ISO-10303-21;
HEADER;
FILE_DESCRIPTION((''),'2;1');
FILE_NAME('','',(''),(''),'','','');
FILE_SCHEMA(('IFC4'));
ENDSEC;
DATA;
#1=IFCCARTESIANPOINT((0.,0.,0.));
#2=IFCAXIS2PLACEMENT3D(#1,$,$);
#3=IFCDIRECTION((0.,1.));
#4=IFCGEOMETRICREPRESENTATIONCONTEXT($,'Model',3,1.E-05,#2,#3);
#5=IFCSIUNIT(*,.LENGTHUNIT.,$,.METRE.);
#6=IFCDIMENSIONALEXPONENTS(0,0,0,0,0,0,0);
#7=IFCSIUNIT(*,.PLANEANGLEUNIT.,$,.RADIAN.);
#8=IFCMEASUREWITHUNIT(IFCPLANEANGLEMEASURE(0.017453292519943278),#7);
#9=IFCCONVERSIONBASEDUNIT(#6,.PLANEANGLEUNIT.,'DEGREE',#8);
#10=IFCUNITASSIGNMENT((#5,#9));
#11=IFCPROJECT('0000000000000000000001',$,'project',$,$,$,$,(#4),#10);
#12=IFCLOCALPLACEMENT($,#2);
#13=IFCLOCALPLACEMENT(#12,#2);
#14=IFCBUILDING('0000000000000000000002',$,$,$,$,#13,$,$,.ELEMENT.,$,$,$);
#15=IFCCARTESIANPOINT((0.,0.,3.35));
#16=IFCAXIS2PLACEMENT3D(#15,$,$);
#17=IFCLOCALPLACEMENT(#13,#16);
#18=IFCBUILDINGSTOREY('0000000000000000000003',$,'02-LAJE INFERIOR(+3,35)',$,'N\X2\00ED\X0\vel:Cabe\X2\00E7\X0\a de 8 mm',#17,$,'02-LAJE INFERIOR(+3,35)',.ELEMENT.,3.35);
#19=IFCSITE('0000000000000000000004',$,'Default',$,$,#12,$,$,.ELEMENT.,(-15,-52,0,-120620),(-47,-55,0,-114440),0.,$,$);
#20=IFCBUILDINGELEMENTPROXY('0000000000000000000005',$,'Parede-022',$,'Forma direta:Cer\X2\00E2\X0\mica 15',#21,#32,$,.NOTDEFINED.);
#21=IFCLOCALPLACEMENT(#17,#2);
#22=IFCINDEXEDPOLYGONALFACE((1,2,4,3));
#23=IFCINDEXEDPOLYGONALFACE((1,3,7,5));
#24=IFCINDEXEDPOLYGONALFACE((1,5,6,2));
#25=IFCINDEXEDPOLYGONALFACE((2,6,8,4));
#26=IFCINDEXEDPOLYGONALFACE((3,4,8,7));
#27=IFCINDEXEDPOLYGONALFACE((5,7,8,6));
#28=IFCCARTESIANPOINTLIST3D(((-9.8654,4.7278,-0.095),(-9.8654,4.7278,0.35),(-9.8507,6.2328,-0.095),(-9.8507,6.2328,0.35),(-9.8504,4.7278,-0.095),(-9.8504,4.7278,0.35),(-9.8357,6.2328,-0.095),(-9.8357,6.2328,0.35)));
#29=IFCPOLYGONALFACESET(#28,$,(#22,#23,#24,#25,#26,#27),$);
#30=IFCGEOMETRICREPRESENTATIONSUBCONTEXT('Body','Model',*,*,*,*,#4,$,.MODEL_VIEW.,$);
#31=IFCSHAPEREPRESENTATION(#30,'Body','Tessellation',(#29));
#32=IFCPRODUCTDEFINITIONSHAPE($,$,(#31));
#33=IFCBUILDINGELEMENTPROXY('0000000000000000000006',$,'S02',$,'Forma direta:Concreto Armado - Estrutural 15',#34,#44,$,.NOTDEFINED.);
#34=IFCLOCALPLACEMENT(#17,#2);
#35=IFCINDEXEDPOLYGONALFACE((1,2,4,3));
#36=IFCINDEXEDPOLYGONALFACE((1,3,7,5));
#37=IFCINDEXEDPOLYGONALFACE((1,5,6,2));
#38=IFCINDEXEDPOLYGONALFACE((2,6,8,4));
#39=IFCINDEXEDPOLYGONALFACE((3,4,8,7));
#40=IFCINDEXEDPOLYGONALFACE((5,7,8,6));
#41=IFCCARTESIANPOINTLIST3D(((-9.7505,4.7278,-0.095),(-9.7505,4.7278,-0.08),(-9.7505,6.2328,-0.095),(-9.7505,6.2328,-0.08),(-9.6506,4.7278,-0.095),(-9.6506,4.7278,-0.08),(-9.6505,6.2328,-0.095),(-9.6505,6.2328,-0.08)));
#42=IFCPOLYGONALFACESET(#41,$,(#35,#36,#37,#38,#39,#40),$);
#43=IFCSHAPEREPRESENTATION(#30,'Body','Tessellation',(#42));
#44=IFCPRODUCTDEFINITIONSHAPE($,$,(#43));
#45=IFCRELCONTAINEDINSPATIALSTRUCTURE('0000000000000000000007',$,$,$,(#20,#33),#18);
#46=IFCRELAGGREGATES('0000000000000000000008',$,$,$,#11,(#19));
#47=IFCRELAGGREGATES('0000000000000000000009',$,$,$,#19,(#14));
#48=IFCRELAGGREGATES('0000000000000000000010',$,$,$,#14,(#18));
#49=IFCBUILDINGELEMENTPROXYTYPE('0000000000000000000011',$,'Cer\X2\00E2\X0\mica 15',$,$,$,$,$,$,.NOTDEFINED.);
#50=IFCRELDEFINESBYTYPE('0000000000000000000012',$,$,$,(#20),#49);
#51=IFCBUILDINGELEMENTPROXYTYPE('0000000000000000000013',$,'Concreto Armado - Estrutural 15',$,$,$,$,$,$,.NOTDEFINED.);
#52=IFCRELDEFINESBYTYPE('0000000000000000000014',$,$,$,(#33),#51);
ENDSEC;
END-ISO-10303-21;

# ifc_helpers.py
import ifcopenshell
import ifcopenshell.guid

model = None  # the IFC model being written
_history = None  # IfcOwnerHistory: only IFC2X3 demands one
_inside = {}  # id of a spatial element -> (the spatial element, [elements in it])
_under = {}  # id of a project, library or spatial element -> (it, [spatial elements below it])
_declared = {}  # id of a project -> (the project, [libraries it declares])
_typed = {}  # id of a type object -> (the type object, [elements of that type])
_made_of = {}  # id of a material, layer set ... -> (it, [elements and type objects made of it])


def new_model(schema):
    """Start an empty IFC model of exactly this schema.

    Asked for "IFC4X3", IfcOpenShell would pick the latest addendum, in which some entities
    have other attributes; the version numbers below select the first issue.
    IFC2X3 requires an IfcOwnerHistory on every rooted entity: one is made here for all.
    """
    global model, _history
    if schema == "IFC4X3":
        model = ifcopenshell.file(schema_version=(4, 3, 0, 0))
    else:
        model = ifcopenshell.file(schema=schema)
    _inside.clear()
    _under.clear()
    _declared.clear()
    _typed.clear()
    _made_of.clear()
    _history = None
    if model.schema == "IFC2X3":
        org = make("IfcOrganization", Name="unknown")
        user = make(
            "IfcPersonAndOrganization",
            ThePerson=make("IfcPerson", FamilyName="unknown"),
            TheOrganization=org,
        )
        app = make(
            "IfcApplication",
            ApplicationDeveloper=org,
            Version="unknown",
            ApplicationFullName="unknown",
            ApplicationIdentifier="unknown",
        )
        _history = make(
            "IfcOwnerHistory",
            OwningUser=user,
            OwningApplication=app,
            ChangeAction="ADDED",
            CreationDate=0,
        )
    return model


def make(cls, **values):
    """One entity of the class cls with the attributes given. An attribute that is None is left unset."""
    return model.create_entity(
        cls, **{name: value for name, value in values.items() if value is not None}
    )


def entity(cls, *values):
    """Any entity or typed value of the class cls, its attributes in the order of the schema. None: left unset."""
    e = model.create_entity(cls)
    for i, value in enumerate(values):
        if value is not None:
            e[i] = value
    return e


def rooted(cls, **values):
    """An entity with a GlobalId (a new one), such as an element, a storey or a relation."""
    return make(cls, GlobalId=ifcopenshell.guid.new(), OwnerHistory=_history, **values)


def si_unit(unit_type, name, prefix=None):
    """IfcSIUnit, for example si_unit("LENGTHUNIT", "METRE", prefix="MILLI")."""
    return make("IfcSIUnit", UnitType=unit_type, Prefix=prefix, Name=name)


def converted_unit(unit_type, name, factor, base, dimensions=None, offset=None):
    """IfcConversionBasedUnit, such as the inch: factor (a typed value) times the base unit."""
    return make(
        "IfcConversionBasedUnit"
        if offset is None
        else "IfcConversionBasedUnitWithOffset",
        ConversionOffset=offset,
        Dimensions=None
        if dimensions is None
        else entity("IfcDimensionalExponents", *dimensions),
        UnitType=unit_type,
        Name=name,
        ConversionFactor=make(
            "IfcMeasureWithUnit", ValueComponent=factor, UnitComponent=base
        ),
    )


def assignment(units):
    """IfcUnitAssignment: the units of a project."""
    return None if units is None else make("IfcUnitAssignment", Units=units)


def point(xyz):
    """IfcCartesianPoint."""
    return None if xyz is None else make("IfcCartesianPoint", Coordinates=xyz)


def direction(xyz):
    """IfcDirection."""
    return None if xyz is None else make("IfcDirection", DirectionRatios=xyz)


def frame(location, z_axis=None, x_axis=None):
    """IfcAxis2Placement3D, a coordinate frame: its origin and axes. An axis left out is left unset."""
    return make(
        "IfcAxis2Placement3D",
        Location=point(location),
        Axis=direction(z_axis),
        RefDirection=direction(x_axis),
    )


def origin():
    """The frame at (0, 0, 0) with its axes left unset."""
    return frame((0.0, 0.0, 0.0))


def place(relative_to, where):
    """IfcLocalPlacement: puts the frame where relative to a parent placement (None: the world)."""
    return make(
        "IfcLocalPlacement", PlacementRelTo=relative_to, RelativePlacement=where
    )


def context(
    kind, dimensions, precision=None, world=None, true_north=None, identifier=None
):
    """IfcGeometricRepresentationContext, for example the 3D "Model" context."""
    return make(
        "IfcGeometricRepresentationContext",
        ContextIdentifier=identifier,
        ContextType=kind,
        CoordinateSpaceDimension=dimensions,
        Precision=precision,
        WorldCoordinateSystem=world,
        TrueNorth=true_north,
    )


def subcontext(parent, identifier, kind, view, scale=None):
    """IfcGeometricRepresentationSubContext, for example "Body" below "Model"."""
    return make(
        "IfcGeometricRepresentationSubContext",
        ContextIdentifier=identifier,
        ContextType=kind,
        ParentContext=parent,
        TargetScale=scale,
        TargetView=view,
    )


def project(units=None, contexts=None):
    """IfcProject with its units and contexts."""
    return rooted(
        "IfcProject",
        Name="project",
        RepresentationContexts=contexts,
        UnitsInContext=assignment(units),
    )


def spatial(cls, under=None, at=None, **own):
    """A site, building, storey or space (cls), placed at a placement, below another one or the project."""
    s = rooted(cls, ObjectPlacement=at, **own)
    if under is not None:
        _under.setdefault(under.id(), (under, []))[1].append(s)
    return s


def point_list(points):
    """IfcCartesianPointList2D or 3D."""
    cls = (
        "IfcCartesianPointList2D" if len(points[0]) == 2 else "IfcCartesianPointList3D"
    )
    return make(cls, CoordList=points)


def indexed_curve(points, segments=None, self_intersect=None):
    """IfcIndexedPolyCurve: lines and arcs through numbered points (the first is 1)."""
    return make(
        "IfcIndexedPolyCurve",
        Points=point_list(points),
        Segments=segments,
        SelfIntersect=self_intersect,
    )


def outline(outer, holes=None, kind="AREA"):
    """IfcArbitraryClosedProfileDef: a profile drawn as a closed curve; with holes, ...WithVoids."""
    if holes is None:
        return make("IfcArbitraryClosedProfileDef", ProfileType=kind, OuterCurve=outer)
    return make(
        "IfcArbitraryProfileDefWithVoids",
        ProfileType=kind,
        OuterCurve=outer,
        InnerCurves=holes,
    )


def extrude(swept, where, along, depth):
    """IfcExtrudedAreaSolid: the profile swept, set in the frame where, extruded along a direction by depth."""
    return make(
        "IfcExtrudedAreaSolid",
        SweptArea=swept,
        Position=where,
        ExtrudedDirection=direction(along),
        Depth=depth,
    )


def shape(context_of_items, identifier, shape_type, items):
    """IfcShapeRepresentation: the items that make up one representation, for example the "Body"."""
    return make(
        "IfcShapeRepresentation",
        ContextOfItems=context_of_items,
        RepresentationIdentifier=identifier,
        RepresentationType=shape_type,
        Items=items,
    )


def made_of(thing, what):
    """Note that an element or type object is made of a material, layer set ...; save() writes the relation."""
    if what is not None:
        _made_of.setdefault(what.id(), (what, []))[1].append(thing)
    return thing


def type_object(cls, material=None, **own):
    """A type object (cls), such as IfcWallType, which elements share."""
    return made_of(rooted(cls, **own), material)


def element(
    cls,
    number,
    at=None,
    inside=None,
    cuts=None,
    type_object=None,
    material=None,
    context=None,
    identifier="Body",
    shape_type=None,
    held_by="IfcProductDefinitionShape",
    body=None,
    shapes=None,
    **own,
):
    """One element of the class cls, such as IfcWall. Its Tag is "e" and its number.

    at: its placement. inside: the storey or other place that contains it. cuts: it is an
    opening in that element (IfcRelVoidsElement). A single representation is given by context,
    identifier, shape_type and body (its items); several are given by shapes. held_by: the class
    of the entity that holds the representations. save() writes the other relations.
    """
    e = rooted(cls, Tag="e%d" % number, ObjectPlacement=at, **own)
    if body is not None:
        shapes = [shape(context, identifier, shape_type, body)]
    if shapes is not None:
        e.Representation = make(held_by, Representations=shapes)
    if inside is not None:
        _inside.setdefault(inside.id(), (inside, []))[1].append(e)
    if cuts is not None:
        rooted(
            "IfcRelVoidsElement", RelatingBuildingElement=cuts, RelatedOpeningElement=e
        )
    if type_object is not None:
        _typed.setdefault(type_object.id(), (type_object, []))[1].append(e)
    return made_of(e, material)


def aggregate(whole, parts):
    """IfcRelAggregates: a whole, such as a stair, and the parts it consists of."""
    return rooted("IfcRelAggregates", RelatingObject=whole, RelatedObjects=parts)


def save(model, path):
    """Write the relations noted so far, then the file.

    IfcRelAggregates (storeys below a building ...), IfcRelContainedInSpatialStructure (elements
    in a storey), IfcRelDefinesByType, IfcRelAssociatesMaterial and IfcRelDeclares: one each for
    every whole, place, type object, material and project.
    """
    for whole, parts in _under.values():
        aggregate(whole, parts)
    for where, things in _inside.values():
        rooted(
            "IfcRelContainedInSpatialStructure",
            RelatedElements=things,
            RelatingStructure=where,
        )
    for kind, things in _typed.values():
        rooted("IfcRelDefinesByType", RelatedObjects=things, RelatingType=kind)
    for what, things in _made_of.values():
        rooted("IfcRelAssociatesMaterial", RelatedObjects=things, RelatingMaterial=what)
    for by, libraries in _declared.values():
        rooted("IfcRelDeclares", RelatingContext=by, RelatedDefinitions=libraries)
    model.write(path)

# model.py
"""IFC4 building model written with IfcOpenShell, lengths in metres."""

from ifc_helpers import new_model, entity, si_unit, converted_unit, direction, frame, origin, place, context, subcontext, project, spatial, indexed_curve, outline, extrude, type_object, element, save


model = new_model("IFC4")

# Units and contexts
model_context = context("Model", 3, precision=1e-05, world=origin(), true_north=direction((0.0, 1.0)))
body_context = subcontext(model_context, "Body", "Model", "MODEL_VIEW")
ifc_project = project(units=[si_unit("LENGTHUNIT", "METRE"), converted_unit("PLANEANGLEUNIT", "DEGREE", entity("IfcPlaneAngleMeasure", 0.017453292519943278), si_unit("PLANEANGLEUNIT", "RADIAN"), dimensions=[0, 0, 0, 0, 0, 0, 0])], contexts=[model_context])

# Site, building, storey
site_placement = place(None, origin())
site = spatial("IfcSite", under=ifc_project, at=site_placement, Name="Default", CompositionType="ELEMENT", RefLatitude=(-15, -52, 0, -120620), RefLongitude=(-47, -55, 0, -114440), RefElevation=0.0)
building_placement = place(site_placement, origin())
building = spatial("IfcBuilding", under=site, at=building_placement, CompositionType="ELEMENT")
storey_placement = place(building_placement, frame((0.0, 0.0, 3.35)))
storey = spatial("IfcBuildingStorey", under=building, at=storey_placement, Name="02-LAJE INFERIOR(+3,35)", ObjectType="Nível:Cabeça de 8 mm", LongName="02-LAJE INFERIOR(+3,35)", CompositionType="ELEMENT", Elevation=3.35)

# Building element proxies
building_element_proxy_type_1 = type_object("IfcBuildingElementProxyType", Name="Cerâmica 15", PredefinedType="NOTDEFINED")
proxy_1_placement = place(storey_placement, origin())
element("IfcBuildingElementProxy", 1, at=proxy_1_placement, inside=storey, type_object=building_element_proxy_type_1, Name="Parede-022", ObjectType="Forma direta:Cerâmica 15", PredefinedType="NOTDEFINED", context=body_context, shape_type="SweptSolid", body=[
    extrude(outline(indexed_curve([(-0.0148, -0.7525), (0.0002, -0.7525), (0.0148, 0.7525), (-0.0002, 0.7525), (-0.0148, -0.7525)], self_intersect=False)), frame((-9.8505, 5.4803, -0.095), z_axis=(0.0, 0.0, 1.0), x_axis=(-1.0, 0.000013, 0.0)), (0.0, 0.0, 1.0), 0.445),
])
building_element_proxy_type_2 = type_object("IfcBuildingElementProxyType", Name="Concreto Armado - Estrutural 15", PredefinedType="NOTDEFINED")
proxy_2_placement = place(storey_placement, origin())
element("IfcBuildingElementProxy", 2, at=proxy_2_placement, inside=storey, type_object=building_element_proxy_type_2, Name="S02", ObjectType="Forma direta:Concreto Armado - Estrutural 15", PredefinedType="NOTDEFINED", context=body_context, shape_type="SweptSolid", body=[
    extrude(outline(indexed_curve([(-0.7525, -0.05), (0.7525, -0.05), (0.7525, 0.05), (-0.7525, 0.05), (-0.7525, -0.05)], self_intersect=False)), frame((-9.7005, 5.4803, -0.095), z_axis=(0.0, 0.0, 1.0), x_axis=(0.000013, 1.0, 0.0)), (0.0, 0.0, 1.0), 0.015),
])

save(model, "model.ifc")
